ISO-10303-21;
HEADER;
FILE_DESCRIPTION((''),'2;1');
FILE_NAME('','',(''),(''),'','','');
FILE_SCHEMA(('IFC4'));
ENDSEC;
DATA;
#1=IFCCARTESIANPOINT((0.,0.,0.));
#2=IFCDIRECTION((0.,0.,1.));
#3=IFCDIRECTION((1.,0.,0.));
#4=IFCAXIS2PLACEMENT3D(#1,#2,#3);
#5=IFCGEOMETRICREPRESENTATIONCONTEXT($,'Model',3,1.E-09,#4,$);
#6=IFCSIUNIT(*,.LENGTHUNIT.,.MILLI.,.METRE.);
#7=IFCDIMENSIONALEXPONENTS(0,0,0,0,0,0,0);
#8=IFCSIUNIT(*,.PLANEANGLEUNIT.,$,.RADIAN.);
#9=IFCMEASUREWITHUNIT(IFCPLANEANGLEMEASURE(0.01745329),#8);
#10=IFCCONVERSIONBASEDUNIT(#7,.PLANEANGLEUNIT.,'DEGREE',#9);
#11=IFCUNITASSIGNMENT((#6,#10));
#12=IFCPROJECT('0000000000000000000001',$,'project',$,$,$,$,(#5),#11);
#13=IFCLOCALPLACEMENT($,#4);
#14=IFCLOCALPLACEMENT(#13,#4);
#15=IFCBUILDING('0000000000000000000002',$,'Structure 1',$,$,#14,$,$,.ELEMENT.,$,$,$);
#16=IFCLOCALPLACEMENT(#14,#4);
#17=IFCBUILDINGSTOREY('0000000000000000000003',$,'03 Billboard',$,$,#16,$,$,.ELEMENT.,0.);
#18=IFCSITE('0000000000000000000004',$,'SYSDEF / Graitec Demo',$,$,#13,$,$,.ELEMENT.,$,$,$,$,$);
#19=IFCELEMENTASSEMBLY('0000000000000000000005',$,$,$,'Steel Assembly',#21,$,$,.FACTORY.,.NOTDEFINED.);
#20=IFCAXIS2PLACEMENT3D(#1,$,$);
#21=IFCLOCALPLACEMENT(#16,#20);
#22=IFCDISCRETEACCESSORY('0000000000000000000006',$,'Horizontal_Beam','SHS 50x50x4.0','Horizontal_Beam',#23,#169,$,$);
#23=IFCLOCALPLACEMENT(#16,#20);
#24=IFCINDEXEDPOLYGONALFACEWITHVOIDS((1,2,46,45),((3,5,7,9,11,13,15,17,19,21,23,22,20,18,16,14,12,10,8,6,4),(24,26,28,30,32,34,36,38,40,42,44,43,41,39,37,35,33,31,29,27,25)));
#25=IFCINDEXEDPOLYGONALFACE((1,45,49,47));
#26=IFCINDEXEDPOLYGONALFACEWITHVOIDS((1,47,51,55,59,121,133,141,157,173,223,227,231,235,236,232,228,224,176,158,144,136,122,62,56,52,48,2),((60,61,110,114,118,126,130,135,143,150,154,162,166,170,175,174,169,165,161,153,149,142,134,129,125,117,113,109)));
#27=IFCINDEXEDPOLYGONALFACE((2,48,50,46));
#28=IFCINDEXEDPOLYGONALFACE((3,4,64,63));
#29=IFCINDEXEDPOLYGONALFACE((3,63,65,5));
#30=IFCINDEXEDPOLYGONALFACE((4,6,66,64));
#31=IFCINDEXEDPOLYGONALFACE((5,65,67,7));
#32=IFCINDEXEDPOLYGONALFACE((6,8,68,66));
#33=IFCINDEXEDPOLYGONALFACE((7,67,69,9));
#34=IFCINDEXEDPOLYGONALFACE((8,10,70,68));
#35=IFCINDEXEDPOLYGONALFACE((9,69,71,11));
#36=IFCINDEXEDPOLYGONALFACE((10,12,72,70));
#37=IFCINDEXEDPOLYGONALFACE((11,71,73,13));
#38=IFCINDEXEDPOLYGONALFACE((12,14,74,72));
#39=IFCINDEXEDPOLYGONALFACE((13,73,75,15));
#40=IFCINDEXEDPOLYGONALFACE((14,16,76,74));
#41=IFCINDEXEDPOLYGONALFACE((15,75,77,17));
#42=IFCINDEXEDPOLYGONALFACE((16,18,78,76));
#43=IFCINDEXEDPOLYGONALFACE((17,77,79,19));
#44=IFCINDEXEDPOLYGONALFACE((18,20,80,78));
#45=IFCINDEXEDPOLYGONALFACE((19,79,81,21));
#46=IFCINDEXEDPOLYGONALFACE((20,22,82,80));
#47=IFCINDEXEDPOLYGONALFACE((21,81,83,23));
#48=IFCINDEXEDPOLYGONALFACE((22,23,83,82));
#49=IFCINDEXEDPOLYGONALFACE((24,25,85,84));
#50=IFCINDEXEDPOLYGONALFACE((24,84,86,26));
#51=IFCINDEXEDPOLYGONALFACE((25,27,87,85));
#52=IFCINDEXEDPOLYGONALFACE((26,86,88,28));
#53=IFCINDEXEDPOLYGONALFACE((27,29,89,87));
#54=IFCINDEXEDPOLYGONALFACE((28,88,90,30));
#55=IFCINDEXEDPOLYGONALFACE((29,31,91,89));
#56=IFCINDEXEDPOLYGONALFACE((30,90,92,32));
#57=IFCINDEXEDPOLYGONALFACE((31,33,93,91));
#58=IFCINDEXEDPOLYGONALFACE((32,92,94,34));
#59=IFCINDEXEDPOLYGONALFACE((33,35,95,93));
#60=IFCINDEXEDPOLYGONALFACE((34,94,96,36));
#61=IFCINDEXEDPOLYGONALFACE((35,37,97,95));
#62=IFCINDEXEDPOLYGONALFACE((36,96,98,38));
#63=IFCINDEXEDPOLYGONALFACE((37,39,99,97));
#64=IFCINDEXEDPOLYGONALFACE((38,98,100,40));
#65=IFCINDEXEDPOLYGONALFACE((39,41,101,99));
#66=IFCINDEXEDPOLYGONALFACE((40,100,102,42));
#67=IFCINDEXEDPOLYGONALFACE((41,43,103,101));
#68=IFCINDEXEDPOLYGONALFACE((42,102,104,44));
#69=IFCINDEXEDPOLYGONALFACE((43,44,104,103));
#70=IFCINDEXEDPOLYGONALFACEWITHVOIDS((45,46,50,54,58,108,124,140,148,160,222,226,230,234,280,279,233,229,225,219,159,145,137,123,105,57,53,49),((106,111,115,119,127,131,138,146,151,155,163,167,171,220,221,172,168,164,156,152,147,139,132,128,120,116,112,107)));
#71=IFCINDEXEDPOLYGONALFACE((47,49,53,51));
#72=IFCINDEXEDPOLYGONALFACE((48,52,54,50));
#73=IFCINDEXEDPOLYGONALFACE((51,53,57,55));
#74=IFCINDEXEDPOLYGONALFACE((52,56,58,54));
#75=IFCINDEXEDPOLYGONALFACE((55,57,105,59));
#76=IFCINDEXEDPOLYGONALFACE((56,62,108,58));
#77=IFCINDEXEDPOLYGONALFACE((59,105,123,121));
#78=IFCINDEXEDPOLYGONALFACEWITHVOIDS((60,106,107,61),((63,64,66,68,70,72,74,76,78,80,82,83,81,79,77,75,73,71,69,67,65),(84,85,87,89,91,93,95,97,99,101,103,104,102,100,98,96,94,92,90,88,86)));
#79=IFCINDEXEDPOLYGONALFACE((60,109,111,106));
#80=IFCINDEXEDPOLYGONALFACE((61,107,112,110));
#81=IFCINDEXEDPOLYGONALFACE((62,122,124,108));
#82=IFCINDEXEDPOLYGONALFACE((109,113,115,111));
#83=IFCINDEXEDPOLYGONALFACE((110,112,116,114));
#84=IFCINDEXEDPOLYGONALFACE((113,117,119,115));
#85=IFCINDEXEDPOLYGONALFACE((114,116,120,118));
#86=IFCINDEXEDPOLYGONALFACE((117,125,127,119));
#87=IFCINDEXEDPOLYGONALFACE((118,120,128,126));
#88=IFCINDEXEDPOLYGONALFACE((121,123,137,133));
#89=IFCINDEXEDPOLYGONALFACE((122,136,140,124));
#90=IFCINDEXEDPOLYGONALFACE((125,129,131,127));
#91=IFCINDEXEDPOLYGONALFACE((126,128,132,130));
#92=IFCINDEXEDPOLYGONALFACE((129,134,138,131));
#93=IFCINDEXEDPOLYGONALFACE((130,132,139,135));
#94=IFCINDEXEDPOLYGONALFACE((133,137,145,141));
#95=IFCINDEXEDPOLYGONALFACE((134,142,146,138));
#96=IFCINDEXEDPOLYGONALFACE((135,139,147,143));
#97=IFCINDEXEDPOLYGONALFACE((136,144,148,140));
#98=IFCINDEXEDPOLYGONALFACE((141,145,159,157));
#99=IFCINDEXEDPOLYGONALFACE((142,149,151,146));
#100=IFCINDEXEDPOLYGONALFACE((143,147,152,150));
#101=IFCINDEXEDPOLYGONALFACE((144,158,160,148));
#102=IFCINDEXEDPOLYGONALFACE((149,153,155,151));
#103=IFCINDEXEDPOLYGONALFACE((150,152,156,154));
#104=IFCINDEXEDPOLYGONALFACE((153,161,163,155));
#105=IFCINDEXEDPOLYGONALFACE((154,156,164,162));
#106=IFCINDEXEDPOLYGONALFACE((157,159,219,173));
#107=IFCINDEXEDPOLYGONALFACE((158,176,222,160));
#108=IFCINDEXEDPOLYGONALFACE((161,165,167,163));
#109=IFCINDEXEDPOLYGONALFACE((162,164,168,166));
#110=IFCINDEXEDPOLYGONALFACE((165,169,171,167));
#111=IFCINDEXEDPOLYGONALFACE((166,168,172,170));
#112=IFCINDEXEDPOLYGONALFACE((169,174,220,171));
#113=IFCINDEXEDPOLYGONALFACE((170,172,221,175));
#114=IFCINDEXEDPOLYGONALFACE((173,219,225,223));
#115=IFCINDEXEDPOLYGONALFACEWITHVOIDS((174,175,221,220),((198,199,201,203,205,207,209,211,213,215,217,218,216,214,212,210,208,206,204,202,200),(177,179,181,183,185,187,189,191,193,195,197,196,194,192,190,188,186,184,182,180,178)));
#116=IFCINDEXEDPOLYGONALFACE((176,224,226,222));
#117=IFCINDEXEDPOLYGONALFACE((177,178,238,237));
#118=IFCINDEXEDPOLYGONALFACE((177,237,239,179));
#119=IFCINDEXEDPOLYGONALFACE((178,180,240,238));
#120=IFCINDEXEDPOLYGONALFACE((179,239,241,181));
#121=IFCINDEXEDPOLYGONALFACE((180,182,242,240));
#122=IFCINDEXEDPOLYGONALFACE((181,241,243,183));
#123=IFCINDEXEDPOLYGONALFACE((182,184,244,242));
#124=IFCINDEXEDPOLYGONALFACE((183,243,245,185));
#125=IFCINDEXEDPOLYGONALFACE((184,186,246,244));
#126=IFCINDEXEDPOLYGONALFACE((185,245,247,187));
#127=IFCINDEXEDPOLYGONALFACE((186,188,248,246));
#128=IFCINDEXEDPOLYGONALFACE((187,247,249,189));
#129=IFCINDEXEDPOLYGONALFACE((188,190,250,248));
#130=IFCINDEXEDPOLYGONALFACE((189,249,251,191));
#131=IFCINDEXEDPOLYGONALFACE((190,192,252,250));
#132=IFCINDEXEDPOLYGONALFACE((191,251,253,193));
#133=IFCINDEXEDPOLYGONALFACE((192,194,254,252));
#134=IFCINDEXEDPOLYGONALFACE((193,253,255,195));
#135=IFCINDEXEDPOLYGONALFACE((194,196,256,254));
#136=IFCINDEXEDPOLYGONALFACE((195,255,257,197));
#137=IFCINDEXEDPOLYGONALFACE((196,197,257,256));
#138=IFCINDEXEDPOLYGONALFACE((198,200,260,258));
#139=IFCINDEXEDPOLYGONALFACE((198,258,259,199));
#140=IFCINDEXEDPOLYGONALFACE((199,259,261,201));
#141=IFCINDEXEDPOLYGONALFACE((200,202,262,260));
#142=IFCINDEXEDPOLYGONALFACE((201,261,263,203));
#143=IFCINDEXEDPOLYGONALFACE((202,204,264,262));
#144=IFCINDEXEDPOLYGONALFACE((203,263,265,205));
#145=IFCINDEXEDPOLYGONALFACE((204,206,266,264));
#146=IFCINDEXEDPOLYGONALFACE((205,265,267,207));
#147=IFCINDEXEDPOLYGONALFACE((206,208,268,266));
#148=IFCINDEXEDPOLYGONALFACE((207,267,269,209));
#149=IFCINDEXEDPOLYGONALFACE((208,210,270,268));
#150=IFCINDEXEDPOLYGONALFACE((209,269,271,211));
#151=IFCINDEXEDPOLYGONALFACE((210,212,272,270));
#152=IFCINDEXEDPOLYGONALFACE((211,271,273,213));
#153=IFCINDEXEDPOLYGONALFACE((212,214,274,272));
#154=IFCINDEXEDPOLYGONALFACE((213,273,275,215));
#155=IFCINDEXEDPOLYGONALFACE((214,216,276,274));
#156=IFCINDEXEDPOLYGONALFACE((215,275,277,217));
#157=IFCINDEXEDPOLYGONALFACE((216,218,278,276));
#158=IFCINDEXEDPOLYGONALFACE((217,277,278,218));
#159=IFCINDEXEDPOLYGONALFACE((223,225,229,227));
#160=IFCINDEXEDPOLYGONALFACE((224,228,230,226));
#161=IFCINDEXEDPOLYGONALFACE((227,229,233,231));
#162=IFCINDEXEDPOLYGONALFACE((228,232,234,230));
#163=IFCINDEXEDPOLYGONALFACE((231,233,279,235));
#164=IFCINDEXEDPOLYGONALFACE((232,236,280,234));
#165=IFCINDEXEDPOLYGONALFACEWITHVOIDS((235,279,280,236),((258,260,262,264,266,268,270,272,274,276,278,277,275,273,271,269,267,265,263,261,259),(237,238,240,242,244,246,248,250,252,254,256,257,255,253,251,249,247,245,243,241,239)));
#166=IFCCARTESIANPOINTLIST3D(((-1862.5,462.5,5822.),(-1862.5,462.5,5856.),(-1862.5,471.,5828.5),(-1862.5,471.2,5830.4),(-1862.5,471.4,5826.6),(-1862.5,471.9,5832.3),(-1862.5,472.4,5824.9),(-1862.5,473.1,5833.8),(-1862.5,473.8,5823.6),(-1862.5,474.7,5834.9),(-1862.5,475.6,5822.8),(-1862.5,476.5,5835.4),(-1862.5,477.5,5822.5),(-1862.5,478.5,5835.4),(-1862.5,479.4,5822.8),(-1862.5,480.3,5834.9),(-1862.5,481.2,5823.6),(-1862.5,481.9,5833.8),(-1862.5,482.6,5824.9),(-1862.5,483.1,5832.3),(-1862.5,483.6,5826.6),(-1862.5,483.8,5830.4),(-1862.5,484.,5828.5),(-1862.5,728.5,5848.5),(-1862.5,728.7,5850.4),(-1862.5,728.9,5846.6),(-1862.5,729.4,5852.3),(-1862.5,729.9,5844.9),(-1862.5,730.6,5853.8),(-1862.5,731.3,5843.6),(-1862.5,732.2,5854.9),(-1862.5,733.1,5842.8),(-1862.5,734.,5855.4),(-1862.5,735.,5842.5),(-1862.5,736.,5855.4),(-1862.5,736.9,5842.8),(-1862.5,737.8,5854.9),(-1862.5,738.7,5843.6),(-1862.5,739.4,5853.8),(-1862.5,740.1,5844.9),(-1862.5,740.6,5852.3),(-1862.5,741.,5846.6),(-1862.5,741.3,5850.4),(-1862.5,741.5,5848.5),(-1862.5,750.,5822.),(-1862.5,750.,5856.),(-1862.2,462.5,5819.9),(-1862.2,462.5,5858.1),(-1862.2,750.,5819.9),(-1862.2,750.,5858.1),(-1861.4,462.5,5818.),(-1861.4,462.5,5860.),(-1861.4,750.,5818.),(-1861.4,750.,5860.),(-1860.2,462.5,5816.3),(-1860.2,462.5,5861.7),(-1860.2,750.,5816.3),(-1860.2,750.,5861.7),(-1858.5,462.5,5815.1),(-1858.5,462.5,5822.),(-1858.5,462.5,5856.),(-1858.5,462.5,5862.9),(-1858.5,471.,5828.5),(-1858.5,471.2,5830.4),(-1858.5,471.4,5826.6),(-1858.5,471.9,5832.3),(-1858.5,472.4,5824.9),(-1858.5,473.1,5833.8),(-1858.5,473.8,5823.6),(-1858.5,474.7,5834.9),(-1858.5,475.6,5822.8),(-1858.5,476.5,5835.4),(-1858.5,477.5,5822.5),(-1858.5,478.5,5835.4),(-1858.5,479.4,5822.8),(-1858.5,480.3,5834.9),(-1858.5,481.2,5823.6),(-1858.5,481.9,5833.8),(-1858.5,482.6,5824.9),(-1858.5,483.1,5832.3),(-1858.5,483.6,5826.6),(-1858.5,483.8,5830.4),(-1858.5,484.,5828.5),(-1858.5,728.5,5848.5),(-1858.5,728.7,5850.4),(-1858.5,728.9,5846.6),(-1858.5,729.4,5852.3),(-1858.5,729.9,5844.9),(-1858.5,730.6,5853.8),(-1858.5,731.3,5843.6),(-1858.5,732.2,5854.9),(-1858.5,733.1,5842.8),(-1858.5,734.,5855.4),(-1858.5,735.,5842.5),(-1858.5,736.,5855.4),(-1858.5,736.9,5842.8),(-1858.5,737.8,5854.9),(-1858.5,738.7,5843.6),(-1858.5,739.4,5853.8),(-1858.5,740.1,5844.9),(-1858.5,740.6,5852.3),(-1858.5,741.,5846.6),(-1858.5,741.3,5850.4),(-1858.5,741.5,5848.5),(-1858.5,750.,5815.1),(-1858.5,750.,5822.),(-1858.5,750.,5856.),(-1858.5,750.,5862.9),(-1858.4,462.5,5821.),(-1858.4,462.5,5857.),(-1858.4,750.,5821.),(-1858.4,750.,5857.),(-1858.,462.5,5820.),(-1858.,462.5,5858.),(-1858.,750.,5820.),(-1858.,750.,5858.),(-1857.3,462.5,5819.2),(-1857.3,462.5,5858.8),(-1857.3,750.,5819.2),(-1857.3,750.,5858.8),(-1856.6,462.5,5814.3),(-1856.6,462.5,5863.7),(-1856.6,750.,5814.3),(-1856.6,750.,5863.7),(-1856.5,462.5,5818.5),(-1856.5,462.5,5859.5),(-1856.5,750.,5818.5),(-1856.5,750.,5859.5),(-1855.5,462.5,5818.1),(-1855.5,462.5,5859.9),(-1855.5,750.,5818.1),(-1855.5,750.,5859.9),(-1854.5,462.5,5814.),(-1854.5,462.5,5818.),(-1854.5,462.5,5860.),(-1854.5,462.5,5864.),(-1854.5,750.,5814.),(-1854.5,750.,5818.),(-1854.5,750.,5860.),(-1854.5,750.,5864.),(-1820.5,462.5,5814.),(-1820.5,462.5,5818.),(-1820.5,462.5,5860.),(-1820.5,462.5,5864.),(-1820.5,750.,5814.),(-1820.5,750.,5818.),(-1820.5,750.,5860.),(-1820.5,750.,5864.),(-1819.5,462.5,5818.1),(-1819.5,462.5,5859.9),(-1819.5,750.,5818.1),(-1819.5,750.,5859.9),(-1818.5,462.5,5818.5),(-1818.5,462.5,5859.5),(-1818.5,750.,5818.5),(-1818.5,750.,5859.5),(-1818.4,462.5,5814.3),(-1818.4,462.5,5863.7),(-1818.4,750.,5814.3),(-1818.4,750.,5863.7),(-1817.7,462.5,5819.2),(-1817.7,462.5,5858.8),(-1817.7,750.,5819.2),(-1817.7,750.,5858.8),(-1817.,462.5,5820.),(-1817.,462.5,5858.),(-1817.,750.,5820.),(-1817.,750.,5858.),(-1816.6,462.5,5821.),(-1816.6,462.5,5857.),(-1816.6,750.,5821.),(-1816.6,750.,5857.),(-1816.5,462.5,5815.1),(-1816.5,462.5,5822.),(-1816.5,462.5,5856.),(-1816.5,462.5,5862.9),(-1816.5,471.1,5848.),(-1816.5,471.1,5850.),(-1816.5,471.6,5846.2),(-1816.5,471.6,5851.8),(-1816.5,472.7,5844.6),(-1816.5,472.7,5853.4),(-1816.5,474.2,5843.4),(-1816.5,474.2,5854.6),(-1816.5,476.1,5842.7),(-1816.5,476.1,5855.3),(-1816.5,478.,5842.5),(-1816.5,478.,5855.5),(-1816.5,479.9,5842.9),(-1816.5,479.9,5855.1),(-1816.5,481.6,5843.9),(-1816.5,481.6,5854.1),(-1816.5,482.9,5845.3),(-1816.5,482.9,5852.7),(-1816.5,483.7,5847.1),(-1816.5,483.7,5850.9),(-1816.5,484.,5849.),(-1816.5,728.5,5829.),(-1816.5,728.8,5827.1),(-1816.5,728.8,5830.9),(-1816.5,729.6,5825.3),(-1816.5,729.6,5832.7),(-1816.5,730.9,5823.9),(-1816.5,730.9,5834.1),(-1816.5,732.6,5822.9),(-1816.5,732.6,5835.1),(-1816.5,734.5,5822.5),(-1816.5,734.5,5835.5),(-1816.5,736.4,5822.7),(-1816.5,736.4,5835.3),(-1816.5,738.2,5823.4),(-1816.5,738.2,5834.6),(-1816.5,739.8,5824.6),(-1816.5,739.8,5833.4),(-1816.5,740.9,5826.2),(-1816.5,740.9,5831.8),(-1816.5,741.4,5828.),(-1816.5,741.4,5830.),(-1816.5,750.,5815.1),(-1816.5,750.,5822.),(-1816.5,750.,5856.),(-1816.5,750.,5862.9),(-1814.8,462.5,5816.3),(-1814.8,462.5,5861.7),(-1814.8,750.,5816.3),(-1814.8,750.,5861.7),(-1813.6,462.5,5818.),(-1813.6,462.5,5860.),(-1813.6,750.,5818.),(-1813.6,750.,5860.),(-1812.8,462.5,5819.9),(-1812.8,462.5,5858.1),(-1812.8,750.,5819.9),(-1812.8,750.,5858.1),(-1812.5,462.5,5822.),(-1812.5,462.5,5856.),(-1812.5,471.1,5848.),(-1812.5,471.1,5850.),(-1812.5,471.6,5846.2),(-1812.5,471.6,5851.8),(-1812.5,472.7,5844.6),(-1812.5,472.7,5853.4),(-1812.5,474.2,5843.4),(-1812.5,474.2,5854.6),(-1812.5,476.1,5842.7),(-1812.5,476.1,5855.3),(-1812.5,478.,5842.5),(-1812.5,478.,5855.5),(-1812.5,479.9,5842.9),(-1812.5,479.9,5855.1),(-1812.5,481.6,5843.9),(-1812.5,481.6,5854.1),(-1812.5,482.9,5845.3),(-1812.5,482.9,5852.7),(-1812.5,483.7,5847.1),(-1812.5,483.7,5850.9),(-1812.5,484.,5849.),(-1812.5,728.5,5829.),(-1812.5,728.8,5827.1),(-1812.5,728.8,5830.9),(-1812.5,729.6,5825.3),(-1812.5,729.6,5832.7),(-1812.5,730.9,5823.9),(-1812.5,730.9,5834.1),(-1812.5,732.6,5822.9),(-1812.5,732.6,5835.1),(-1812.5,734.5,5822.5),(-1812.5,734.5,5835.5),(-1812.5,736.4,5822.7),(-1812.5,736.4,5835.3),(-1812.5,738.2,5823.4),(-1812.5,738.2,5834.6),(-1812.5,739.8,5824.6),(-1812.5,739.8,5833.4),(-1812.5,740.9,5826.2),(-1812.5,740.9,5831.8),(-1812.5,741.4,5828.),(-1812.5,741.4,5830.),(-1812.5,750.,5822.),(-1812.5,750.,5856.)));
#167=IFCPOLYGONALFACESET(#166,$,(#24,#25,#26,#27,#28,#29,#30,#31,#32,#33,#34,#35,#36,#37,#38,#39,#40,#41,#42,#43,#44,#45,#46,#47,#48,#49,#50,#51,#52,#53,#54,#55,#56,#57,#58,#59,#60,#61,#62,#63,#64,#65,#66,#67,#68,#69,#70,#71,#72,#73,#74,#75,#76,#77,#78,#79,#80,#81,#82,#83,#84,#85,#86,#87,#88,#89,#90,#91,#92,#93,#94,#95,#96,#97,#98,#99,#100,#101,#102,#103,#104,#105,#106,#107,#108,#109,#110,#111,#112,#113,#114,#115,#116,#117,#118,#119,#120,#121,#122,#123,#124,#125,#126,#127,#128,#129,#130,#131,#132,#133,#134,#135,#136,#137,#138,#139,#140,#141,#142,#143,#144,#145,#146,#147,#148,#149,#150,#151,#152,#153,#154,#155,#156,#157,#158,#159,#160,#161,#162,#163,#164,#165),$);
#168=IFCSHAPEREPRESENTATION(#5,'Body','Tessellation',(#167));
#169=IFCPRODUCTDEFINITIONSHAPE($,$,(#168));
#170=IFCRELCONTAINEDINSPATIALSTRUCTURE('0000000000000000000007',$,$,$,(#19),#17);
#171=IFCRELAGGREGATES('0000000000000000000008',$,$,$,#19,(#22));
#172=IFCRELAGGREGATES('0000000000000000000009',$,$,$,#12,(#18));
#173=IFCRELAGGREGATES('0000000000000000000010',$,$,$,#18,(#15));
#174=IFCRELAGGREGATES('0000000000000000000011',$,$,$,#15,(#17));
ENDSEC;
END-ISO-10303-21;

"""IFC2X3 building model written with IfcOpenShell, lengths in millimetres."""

from ifc_helpers import new_model, entity, si_unit, converted_unit, frame, frame_2d, origin, origin_with_axes, origin_2d, origin_2d_with_axis, place, context, project, spatial, hollow_rectangle, circle, extrude, clip, halfspace, element, aggregate, save


model = new_model("IFC2X3")

# Units and contexts
model_context = context("Model", 3, precision=1e-09, world=origin_with_axes())
ifc_project = project(units=[si_unit("LENGTHUNIT", "METRE", prefix="MILLI"), converted_unit("PLANEANGLEUNIT", "DEGREE", entity("IfcPlaneAngleMeasure", 0.01745329), si_unit("PLANEANGLEUNIT", "RADIAN"), dimensions=[0, 0, 0, 0, 0, 0, 0])], contexts=[model_context])

# Site, building, storey
site_placement = place(None, origin_with_axes())
site = spatial("IfcSite", under=ifc_project, at=site_placement, Name="SYSDEF / Graitec Demo", CompositionType="ELEMENT")
building_placement = place(site_placement, origin_with_axes())
building = spatial("IfcBuilding", under=site, at=building_placement, Name="Structure 1", CompositionType="ELEMENT")
storey_placement = place(building_placement, origin_with_axes())
storey = spatial("IfcBuildingStorey", under=building, at=storey_placement, Name="03 Billboard", CompositionType="ELEMENT", Elevation=0.0)

# Element assembly, discrete accessory, openings
assembly_placement = place(None, frame((-4239.1, -387.5, 4000.0), z_axis=(-1.0, 0.0, 0.0), x_axis=(0.0, 0.0, 1.0)))
assembly = element("IfcElementAssembly", 1, at=assembly_placement, inside=storey, ObjectType="Steel Assembly", AssemblyPlace="FACTORY", PredefinedType="NOTDEFINED")
discrete_accessory_1_placement = place(assembly_placement, frame((1839.0, 739.6, -2401.6), z_axis=(0.0, -1.0, 0.0), x_axis=(0.0, 0.0, -1.0)))
discrete_accessory_1 = element("IfcDiscreteAccessory", 2, at=discrete_accessory_1_placement, Name="Horizontal_Beam", Description="SHS 50x50x4.0", ObjectType="Horizontal_Beam", context=model_context, shape_type="Clipping", body=[
    clip(clip(extrude(hollow_rectangle(XDim=50.0, YDim=50.0, WallThickness=4.0, InnerFilletRadius=4.0, OuterFilletRadius=8.0, at=origin_2d()), origin(), (0.0, 0.0, -1.0), 483.2), halfspace(frame((1837.5, -5839.0, -110.4), z_axis=(0.0, 0.0, -1.0), x_axis=(-1.0, 0.0, 0.0)), True)), halfspace(frame((1837.5, -5839.0, -397.9), z_axis=(0.0, 0.0, 1.0), x_axis=(1.0, 0.0, 0.0)), True)),
])
opening_1_placement = place(discrete_accessory_1_placement, frame((20.5, -10.0, -382.9), z_axis=(1.0, 0.0, 0.0), x_axis=(0.0, 0.0, 1.0)))
element("IfcOpeningElement", 3, at=opening_1_placement, cuts=discrete_accessory_1, ObjectType="Opening", context=model_context, shape_type="SweptSolid", body=[
    extrude(circle(Radius=6.5, at=origin_2d_with_axis()), origin(), (0.0, 0.0, 1.0), 5.0),
])
opening_2_placement = place(discrete_accessory_1_placement, frame((20.5, 10.0, -125.4), z_axis=(1.0, 0.0, 0.0), x_axis=(0.0, 0.0, -1.0)))
element("IfcOpeningElement", 4, at=opening_2_placement, cuts=discrete_accessory_1, ObjectType="Opening", context=model_context, shape_type="SweptSolid", body=[
    extrude(circle(Radius=6.5, at=origin_2d_with_axis()), origin(), (0.0, 0.0, 1.0), 5.0),
])
opening_3_placement = place(discrete_accessory_1_placement, frame((-25.5, -10.0, -118.9), z_axis=(-1.0, 0.0, 0.0), x_axis=(0.0, -1.0, 0.0)))
element("IfcOpeningElement", 5, at=opening_3_placement, cuts=discrete_accessory_1, ObjectType="Opening", context=model_context, shape_type="SweptSolid", body=[
    extrude(circle(Radius=6.5, at=frame_2d((0.0, -6.5), x_axis=(1.0, 0.0))), origin(), (0.0, 0.0, -1.0), 5.0),
])
opening_4_placement = place(discrete_accessory_1_placement, frame((-25.5, 10.0, -389.4), z_axis=(-1.0, 0.0, 0.0), x_axis=(0.0, -1.0, 0.0)))
element("IfcOpeningElement", 6, at=opening_4_placement, cuts=discrete_accessory_1, ObjectType="Opening", context=model_context, shape_type="SweptSolid", body=[
    extrude(circle(Radius=6.5, at=frame_2d((0.0, 6.5), x_axis=(1.0, 0.0))), origin(), (0.0, 0.0, -1.0), 5.0),
])
aggregate(assembly, [discrete_accessory_1])

save(model, "model.ifc")
